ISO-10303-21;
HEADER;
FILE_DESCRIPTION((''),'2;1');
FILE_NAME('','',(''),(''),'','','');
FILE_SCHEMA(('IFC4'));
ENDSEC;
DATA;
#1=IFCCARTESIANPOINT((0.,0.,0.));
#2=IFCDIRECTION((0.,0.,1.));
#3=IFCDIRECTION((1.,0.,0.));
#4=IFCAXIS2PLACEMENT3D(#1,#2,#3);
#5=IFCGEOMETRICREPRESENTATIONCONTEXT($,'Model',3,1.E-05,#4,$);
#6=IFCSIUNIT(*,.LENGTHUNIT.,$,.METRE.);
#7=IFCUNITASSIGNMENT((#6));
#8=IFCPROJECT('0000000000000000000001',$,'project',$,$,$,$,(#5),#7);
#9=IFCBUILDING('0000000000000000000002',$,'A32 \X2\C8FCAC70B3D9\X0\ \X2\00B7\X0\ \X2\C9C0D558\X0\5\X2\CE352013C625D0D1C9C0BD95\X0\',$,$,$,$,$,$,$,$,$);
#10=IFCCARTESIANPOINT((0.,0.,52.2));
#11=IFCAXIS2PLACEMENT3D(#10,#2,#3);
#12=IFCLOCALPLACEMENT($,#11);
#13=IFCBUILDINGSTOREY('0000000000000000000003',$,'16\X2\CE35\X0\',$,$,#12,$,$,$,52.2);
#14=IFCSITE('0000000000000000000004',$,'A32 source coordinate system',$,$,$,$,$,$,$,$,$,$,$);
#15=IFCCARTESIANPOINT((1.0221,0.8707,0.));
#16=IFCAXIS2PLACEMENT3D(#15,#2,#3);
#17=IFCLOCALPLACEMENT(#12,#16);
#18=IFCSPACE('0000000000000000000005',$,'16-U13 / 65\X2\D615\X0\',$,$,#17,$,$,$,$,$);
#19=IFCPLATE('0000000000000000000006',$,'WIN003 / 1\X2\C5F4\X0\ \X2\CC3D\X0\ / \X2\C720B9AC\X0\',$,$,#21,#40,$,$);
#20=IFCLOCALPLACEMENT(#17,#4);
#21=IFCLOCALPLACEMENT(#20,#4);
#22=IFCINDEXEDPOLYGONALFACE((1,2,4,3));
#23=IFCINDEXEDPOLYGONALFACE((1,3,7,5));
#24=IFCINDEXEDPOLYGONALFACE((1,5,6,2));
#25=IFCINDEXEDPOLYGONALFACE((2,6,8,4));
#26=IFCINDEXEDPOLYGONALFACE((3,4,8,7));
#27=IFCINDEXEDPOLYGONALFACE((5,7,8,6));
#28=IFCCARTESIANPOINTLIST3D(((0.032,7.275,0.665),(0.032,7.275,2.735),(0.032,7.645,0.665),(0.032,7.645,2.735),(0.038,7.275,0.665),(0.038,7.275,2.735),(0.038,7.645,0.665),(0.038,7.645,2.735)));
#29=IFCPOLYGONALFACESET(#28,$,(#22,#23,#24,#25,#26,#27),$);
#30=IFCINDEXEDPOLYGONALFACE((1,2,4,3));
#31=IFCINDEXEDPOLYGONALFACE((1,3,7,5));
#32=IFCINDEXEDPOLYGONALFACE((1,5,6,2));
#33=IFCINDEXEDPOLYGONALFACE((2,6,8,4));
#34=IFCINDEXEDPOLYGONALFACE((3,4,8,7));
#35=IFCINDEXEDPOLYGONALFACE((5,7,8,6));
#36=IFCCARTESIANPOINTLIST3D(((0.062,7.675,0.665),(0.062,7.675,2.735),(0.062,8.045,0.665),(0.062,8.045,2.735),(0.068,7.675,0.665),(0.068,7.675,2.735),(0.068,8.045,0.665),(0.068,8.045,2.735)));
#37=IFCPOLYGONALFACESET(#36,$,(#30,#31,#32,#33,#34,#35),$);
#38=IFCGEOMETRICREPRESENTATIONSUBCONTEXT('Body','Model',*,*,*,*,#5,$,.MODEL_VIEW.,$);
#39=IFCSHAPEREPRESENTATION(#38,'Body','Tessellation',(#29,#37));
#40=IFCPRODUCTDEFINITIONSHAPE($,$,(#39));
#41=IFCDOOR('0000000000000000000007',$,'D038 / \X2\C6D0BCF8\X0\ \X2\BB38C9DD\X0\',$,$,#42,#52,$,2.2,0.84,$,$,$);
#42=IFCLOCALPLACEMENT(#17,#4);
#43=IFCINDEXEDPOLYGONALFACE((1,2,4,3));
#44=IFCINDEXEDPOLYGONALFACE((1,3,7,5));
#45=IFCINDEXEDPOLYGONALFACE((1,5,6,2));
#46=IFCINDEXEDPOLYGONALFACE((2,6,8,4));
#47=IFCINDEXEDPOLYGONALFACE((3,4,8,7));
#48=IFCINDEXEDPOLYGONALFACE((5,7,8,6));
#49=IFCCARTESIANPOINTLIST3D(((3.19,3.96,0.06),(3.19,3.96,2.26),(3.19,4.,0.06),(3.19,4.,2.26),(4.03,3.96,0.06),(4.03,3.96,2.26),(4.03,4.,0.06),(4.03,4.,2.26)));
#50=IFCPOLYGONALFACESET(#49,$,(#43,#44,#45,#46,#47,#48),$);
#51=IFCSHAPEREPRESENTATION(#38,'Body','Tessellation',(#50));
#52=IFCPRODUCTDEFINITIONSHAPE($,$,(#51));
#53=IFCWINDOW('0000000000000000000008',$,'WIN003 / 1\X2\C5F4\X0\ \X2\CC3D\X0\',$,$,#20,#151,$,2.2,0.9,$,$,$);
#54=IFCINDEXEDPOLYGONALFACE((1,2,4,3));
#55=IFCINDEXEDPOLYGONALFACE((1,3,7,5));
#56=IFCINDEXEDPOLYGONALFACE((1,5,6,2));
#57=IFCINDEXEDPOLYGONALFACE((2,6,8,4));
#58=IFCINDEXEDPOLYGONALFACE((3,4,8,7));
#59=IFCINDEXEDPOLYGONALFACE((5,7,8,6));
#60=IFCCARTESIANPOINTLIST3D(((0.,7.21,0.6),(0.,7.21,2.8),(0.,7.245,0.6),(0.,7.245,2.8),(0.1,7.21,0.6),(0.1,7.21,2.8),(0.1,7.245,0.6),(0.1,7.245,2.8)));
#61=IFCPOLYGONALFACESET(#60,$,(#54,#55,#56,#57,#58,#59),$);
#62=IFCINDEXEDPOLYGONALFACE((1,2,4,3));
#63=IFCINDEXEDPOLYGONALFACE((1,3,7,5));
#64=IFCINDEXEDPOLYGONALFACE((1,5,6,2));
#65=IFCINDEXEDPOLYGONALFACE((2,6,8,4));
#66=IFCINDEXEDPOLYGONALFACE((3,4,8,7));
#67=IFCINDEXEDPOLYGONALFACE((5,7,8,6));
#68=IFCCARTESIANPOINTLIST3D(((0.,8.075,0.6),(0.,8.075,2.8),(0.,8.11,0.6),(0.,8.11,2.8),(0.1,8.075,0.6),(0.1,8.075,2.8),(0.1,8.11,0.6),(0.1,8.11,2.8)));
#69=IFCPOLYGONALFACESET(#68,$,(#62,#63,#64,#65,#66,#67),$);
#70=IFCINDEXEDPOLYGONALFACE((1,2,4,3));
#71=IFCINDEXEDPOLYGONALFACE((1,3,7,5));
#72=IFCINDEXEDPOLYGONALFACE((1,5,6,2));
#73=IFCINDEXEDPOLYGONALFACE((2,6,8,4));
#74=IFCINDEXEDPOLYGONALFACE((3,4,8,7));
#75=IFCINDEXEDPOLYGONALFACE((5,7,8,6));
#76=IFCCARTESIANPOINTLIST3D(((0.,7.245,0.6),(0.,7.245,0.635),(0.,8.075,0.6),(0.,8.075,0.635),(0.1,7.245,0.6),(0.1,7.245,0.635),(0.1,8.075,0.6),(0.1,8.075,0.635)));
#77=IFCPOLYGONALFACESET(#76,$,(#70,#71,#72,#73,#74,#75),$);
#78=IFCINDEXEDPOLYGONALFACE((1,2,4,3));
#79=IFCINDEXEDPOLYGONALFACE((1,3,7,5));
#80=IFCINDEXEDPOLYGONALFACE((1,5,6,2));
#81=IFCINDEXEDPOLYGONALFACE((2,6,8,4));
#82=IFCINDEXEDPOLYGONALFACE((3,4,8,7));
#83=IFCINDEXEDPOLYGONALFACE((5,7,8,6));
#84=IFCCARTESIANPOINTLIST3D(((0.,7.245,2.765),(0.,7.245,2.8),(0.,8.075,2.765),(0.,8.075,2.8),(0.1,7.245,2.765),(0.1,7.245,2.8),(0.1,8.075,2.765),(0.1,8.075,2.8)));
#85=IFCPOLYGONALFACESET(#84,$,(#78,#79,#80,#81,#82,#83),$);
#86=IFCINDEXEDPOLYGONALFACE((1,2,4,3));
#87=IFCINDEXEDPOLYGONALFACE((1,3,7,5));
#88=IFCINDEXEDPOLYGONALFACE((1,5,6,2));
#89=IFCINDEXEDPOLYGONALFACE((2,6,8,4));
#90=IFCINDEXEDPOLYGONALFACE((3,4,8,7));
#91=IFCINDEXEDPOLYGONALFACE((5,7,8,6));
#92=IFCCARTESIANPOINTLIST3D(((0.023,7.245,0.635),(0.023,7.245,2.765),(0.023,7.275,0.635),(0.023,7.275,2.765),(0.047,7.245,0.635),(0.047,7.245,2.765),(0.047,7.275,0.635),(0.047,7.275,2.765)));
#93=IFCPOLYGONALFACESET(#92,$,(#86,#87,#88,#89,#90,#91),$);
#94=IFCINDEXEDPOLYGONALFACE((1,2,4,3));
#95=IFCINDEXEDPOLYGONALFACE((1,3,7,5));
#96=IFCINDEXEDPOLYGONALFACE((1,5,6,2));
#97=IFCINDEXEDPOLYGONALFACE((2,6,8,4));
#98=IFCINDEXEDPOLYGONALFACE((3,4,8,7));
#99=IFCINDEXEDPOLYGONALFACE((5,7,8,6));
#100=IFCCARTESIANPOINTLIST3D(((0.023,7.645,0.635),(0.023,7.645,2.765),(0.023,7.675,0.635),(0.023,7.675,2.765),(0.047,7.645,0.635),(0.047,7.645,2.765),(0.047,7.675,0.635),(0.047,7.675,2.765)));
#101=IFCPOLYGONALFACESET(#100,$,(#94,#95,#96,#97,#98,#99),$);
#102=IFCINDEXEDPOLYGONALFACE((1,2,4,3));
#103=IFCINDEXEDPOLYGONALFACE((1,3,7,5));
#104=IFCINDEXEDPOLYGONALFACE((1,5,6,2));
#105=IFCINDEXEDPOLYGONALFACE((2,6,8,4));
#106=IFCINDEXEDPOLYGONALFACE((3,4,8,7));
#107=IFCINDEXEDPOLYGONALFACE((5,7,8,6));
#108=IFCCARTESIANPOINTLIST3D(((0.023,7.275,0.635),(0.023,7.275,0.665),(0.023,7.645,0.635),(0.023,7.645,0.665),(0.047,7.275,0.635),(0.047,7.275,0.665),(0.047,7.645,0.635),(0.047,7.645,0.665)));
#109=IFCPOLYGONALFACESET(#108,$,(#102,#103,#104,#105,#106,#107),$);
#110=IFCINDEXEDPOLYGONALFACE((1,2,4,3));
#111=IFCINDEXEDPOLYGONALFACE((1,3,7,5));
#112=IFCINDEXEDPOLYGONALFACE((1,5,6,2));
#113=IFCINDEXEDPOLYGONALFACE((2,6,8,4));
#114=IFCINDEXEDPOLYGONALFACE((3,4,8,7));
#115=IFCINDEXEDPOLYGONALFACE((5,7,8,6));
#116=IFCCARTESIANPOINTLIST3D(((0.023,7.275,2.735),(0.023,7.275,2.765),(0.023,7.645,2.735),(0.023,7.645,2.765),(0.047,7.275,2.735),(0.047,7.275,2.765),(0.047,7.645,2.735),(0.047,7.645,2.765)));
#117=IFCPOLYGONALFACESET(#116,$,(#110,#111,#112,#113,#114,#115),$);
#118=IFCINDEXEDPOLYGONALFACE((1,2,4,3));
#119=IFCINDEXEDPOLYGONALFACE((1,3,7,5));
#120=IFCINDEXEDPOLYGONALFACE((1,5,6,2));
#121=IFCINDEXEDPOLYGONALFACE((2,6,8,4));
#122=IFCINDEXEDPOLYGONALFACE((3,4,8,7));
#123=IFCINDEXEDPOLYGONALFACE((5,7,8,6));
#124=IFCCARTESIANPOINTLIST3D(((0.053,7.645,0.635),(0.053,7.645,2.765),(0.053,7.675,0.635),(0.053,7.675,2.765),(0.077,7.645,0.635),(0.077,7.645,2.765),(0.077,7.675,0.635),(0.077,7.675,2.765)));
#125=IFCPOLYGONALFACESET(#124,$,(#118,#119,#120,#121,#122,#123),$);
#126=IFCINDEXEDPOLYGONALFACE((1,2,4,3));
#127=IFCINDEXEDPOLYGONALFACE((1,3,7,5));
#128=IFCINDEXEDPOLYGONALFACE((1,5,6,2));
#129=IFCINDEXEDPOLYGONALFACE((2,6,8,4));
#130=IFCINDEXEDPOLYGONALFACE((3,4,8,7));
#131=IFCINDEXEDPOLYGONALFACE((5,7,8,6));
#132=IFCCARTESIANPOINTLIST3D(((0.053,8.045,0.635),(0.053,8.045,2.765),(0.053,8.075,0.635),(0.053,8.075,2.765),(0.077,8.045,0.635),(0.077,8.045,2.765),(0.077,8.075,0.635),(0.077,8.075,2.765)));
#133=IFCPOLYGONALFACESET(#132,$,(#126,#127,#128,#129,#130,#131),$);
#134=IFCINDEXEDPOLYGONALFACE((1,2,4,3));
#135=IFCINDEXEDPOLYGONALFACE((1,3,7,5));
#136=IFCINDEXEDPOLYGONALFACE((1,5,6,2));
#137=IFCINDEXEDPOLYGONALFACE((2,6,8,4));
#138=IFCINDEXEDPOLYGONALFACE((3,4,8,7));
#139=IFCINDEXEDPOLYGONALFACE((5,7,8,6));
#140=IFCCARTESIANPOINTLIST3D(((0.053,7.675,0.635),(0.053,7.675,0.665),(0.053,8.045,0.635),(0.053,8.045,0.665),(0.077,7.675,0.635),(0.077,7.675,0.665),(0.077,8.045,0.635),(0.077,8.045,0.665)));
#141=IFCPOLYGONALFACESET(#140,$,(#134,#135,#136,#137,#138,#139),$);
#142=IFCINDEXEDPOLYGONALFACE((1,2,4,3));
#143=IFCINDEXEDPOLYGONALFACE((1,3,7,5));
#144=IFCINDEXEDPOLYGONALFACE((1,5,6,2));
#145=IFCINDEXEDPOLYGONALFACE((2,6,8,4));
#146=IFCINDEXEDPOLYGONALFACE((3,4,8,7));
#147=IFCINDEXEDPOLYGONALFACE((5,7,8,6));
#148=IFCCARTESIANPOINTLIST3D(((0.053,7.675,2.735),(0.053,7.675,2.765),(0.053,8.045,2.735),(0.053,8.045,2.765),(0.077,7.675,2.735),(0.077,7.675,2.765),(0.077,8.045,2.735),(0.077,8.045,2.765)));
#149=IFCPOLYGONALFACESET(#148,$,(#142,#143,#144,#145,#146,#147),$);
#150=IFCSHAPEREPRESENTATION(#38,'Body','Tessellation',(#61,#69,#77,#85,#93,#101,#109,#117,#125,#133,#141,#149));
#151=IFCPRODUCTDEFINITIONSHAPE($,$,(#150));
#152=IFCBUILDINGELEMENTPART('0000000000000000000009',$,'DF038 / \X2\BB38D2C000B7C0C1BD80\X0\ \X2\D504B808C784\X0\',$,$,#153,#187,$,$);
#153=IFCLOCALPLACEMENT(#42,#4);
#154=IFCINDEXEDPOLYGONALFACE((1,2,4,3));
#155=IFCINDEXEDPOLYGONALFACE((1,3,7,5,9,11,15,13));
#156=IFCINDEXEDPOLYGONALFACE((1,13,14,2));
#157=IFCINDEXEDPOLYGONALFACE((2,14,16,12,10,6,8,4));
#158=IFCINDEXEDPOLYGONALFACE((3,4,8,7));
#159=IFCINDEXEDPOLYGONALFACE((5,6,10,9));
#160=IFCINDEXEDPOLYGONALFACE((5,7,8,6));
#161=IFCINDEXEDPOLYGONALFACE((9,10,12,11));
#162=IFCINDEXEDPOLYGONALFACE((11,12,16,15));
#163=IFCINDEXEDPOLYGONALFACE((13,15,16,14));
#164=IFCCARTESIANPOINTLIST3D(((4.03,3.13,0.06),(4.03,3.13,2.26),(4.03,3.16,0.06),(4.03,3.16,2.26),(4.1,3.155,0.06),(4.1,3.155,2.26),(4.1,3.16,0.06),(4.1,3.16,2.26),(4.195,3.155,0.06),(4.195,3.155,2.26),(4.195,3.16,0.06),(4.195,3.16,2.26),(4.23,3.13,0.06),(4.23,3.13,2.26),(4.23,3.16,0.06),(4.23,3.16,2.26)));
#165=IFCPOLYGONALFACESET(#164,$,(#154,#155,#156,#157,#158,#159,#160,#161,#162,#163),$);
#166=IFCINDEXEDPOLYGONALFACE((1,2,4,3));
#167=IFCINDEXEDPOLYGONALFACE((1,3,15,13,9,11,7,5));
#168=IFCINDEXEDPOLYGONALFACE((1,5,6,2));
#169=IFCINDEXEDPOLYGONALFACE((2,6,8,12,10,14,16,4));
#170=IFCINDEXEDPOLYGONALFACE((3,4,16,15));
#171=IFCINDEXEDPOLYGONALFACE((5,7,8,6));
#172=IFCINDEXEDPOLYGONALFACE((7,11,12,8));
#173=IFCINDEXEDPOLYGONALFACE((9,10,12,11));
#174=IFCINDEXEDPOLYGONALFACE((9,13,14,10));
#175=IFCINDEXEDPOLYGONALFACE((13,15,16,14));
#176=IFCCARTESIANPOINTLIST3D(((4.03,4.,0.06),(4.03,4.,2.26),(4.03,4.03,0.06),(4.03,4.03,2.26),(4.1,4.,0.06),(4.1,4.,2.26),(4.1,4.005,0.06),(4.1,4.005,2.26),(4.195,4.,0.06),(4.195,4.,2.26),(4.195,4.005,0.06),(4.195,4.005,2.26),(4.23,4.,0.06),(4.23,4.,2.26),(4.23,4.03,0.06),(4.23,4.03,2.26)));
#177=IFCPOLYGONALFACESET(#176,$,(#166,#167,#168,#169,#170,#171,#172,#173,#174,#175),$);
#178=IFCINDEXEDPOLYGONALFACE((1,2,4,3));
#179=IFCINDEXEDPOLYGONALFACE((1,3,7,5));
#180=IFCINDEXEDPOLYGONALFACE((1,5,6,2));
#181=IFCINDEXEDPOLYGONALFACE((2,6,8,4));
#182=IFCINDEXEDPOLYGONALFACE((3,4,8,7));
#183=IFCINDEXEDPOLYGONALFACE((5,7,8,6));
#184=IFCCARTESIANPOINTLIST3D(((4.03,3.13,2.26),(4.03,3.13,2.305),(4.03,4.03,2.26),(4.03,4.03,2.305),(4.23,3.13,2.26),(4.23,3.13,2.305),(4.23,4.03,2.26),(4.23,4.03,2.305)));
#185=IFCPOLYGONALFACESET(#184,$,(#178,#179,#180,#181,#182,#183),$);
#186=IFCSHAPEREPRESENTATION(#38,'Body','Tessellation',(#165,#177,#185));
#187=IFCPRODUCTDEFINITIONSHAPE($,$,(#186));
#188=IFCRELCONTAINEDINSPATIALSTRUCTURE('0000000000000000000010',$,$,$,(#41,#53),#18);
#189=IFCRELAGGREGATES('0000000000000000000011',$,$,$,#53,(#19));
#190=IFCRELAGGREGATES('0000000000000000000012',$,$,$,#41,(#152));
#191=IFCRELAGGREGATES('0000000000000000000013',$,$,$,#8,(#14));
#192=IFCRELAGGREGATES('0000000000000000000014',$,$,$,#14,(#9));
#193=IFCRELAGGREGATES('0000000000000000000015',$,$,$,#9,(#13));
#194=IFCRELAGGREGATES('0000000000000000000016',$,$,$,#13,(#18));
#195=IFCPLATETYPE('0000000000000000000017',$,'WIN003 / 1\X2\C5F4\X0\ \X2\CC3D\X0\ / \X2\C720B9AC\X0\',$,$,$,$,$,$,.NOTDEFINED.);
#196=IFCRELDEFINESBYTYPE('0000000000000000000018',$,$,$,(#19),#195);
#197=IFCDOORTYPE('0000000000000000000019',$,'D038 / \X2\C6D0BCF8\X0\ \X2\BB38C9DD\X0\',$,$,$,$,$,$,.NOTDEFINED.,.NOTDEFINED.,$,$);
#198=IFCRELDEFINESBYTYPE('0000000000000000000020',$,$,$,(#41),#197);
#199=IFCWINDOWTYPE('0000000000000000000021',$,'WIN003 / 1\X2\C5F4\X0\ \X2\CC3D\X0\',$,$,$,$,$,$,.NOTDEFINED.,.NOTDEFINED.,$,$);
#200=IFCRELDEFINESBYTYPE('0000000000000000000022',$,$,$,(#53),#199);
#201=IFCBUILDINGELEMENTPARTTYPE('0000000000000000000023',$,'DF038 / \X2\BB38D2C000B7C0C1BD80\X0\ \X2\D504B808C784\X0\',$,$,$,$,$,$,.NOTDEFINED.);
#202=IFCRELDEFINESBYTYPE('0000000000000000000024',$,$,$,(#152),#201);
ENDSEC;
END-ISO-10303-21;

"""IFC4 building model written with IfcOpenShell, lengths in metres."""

from ifc_helpers import new_model, si_unit, frame, origin, origin_with_axes, place, context, subcontext, project, spatial, polyline, outline, extrude, source, transform, mapped, type_object, type_shapes, element, aggregate, save


model = new_model("IFC4")

# Units and contexts
model_context = context("Model", 3, precision=1e-05, world=origin_with_axes())
body_context = subcontext(model_context, "Body", "Model", "MODEL_VIEW")
ifc_project = project(units=[si_unit("LENGTHUNIT", "METRE")], contexts=[model_context])

# Plate
storey_placement = place(None, frame((0.0, 0.0, 52.2), z_axis=(0.0, 0.0, 1.0), x_axis=(1.0, 0.0, 0.0)))
space_placement = place(storey_placement, frame((1.0221, 0.8707, 0.0), z_axis=(0.0, 0.0, 1.0), x_axis=(1.0, 0.0, 0.0)))
plate_type_1 = type_object("IfcPlateType", Name="WIN003 / 1열 창 / 유리", PredefinedType="NOTDEFINED")
shared_shape_1 = source(origin(), body_context, "Body", "SweptSolid", [
    extrude(outline(polyline([(0.032, 7.275), (0.032, 7.645), (0.038, 7.645), (0.038, 7.275), (0.032, 7.275)])), frame((0.0, 0.0, 0.665)), (0.0, 0.0, 1.0), 2.07),
    extrude(outline(polyline([(0.062, 7.675), (0.062, 8.045), (0.068, 8.045), (0.068, 7.675), (0.062, 7.675)])), frame((0.0, 0.0, 0.665)), (0.0, 0.0, 1.0), 2.07),
])
type_shapes(plate_type_1, [shared_shape_1])
window_1_placement = place(space_placement, origin_with_axes())
plate_1_placement = place(window_1_placement, origin_with_axes())
plate_1 = element("IfcPlate", 1, at=plate_1_placement, type_object=plate_type_1, Name="WIN003 / 1열 창 / 유리", context=body_context, shape_type="MappedRepresentation", body=[
    mapped(shared_shape_1, transform((0.0, 0.0, 0.0), scale=1.0)),
])

# Site, building, storey, space
site = spatial("IfcSite", under=ifc_project, Name="A32 source coordinate system")
building = spatial("IfcBuilding", under=site, Name="A32 주거동 · 지하5층–옥탑지붕")
storey = spatial("IfcBuildingStorey", under=building, at=storey_placement, Name="16층", Elevation=52.2)
space = spatial("IfcSpace", under=storey, at=space_placement, Name="16-U13 / 65형")

# Door
door_type_1 = type_object("IfcDoorType", Name="D038 / 원본 문짝", OperationType="NOTDEFINED", PredefinedType="NOTDEFINED")
shared_shape_2 = source(origin(), body_context, "Body", "SweptSolid", [
    extrude(outline(polyline([(3.19, 3.96), (3.19, 4.0), (4.03, 4.0), (4.03, 3.96), (3.19, 3.96)])), frame((0.0, 0.0, 0.06)), (0.0, 0.0, 1.0), 2.2),
])
type_shapes(door_type_1, [shared_shape_2])
door_1_placement = place(space_placement, origin_with_axes())
door_1 = element("IfcDoor", 2, at=door_1_placement, inside=space, type_object=door_type_1, Name="D038 / 원본 문짝", OverallHeight=2.2, OverallWidth=0.84, context=body_context, shape_type="MappedRepresentation", body=[
    mapped(shared_shape_2, transform((0.0, 0.0, 0.0), scale=1.0)),
])

# Window
window_type_1 = type_object("IfcWindowType", Name="WIN003 / 1열 창", PartitioningType="NOTDEFINED", PredefinedType="NOTDEFINED")
shared_shape_3 = source(origin(), body_context, "Body", "SweptSolid", [
    extrude(outline(polyline([(0.0, 7.21), (0.0, 7.245), (0.1, 7.245), (0.1, 7.21), (0.0, 7.21)])), frame((0.0, 0.0, 0.6)), (0.0, 0.0, 1.0), 2.2),
    extrude(outline(polyline([(0.0, 8.075), (0.0, 8.11), (0.1, 8.11), (0.1, 8.075), (0.0, 8.075)])), frame((0.0, 0.0, 0.6)), (0.0, 0.0, 1.0), 2.2),
    extrude(outline(polyline([(0.0, 7.245), (0.0, 8.075), (0.1, 8.075), (0.1, 7.245), (0.0, 7.245)])), frame((0.0, 0.0, 0.6)), (0.0, 0.0, 1.0), 0.035),
    extrude(outline(polyline([(0.0, 7.245), (0.0, 8.075), (0.1, 8.075), (0.1, 7.245), (0.0, 7.245)])), frame((0.0, 0.0, 2.765)), (0.0, 0.0, 1.0), 0.035),
    extrude(outline(polyline([(0.023, 7.245), (0.023, 7.275), (0.047, 7.275), (0.047, 7.245), (0.023, 7.245)])), frame((0.0, 0.0, 0.635)), (0.0, 0.0, 1.0), 2.13),
    extrude(outline(polyline([(0.023, 7.645), (0.023, 7.675), (0.047, 7.675), (0.047, 7.645), (0.023, 7.645)])), frame((0.0, 0.0, 0.635)), (0.0, 0.0, 1.0), 2.13),
    extrude(outline(polyline([(0.023, 7.275), (0.023, 7.645), (0.047, 7.645), (0.047, 7.275), (0.023, 7.275)])), frame((0.0, 0.0, 0.635)), (0.0, 0.0, 1.0), 0.03),
    extrude(outline(polyline([(0.023, 7.275), (0.023, 7.645), (0.047, 7.645), (0.047, 7.275), (0.023, 7.275)])), frame((0.0, 0.0, 2.735)), (0.0, 0.0, 1.0), 0.03),
    extrude(outline(polyline([(0.053, 7.645), (0.053, 7.675), (0.077, 7.675), (0.077, 7.645), (0.053, 7.645)])), frame((0.0, 0.0, 0.635)), (0.0, 0.0, 1.0), 2.13),
    extrude(outline(polyline([(0.053, 8.045), (0.053, 8.075), (0.077, 8.075), (0.077, 8.045), (0.053, 8.045)])), frame((0.0, 0.0, 0.635)), (0.0, 0.0, 1.0), 2.13),
    extrude(outline(polyline([(0.053, 7.675), (0.053, 8.045), (0.077, 8.045), (0.077, 7.675), (0.053, 7.675)])), frame((0.0, 0.0, 0.635)), (0.0, 0.0, 1.0), 0.03),
    extrude(outline(polyline([(0.053, 7.675), (0.053, 8.045), (0.077, 8.045), (0.077, 7.675), (0.053, 7.675)])), frame((0.0, 0.0, 2.735)), (0.0, 0.0, 1.0), 0.03),
])
type_shapes(window_type_1, [shared_shape_3])
window_1 = element("IfcWindow", 3, at=window_1_placement, inside=space, type_object=window_type_1, Name="WIN003 / 1열 창", OverallHeight=2.2, OverallWidth=0.9, context=body_context, shape_type="MappedRepresentation", body=[
    mapped(shared_shape_3, transform((0.0, 0.0, 0.0), scale=1.0)),
])
aggregate(window_1, [plate_1])

# Building element part
building_element_part_type_1 = type_object("IfcBuildingElementPartType", Name="DF038 / 문틀·상부 프레임", PredefinedType="NOTDEFINED")
shared_shape_4 = source(origin(), body_context, "Body", "SweptSolid", [
    extrude(outline(polyline([(4.03, 3.16), (4.1, 3.16), (4.1, 3.155), (4.195, 3.155), (4.195, 3.16), (4.23, 3.16), (4.23, 3.13), (4.03, 3.13), (4.03, 3.16)])), frame((0.0, 0.0, 0.06)), (0.0, 0.0, 1.0), 2.2),
    extrude(outline(polyline([(4.23, 4.03), (4.23, 4.0), (4.195, 4.0), (4.195, 4.005), (4.1, 4.005), (4.1, 4.0), (4.03, 4.0), (4.03, 4.03), (4.23, 4.03)])), frame((0.0, 0.0, 0.06)), (0.0, 0.0, 1.0), 2.2),
    extrude(outline(polyline([(4.03, 3.13), (4.03, 4.03), (4.23, 4.03), (4.23, 3.13), (4.03, 3.13)])), frame((0.0, 0.0, 2.26)), (0.0, 0.0, 1.0), 0.045),
])
type_shapes(building_element_part_type_1, [shared_shape_4])
building_element_part_1_placement = place(door_1_placement, origin_with_axes())
building_element_part_1 = element("IfcBuildingElementPart", 4, at=building_element_part_1_placement, type_object=building_element_part_type_1, Name="DF038 / 문틀·상부 프레임", context=body_context, shape_type="MappedRepresentation", body=[
    mapped(shared_shape_4, transform((0.0, 0.0, 0.0), scale=1.0)),
])
aggregate(door_1, [building_element_part_1])

save(model, "model.ifc")
